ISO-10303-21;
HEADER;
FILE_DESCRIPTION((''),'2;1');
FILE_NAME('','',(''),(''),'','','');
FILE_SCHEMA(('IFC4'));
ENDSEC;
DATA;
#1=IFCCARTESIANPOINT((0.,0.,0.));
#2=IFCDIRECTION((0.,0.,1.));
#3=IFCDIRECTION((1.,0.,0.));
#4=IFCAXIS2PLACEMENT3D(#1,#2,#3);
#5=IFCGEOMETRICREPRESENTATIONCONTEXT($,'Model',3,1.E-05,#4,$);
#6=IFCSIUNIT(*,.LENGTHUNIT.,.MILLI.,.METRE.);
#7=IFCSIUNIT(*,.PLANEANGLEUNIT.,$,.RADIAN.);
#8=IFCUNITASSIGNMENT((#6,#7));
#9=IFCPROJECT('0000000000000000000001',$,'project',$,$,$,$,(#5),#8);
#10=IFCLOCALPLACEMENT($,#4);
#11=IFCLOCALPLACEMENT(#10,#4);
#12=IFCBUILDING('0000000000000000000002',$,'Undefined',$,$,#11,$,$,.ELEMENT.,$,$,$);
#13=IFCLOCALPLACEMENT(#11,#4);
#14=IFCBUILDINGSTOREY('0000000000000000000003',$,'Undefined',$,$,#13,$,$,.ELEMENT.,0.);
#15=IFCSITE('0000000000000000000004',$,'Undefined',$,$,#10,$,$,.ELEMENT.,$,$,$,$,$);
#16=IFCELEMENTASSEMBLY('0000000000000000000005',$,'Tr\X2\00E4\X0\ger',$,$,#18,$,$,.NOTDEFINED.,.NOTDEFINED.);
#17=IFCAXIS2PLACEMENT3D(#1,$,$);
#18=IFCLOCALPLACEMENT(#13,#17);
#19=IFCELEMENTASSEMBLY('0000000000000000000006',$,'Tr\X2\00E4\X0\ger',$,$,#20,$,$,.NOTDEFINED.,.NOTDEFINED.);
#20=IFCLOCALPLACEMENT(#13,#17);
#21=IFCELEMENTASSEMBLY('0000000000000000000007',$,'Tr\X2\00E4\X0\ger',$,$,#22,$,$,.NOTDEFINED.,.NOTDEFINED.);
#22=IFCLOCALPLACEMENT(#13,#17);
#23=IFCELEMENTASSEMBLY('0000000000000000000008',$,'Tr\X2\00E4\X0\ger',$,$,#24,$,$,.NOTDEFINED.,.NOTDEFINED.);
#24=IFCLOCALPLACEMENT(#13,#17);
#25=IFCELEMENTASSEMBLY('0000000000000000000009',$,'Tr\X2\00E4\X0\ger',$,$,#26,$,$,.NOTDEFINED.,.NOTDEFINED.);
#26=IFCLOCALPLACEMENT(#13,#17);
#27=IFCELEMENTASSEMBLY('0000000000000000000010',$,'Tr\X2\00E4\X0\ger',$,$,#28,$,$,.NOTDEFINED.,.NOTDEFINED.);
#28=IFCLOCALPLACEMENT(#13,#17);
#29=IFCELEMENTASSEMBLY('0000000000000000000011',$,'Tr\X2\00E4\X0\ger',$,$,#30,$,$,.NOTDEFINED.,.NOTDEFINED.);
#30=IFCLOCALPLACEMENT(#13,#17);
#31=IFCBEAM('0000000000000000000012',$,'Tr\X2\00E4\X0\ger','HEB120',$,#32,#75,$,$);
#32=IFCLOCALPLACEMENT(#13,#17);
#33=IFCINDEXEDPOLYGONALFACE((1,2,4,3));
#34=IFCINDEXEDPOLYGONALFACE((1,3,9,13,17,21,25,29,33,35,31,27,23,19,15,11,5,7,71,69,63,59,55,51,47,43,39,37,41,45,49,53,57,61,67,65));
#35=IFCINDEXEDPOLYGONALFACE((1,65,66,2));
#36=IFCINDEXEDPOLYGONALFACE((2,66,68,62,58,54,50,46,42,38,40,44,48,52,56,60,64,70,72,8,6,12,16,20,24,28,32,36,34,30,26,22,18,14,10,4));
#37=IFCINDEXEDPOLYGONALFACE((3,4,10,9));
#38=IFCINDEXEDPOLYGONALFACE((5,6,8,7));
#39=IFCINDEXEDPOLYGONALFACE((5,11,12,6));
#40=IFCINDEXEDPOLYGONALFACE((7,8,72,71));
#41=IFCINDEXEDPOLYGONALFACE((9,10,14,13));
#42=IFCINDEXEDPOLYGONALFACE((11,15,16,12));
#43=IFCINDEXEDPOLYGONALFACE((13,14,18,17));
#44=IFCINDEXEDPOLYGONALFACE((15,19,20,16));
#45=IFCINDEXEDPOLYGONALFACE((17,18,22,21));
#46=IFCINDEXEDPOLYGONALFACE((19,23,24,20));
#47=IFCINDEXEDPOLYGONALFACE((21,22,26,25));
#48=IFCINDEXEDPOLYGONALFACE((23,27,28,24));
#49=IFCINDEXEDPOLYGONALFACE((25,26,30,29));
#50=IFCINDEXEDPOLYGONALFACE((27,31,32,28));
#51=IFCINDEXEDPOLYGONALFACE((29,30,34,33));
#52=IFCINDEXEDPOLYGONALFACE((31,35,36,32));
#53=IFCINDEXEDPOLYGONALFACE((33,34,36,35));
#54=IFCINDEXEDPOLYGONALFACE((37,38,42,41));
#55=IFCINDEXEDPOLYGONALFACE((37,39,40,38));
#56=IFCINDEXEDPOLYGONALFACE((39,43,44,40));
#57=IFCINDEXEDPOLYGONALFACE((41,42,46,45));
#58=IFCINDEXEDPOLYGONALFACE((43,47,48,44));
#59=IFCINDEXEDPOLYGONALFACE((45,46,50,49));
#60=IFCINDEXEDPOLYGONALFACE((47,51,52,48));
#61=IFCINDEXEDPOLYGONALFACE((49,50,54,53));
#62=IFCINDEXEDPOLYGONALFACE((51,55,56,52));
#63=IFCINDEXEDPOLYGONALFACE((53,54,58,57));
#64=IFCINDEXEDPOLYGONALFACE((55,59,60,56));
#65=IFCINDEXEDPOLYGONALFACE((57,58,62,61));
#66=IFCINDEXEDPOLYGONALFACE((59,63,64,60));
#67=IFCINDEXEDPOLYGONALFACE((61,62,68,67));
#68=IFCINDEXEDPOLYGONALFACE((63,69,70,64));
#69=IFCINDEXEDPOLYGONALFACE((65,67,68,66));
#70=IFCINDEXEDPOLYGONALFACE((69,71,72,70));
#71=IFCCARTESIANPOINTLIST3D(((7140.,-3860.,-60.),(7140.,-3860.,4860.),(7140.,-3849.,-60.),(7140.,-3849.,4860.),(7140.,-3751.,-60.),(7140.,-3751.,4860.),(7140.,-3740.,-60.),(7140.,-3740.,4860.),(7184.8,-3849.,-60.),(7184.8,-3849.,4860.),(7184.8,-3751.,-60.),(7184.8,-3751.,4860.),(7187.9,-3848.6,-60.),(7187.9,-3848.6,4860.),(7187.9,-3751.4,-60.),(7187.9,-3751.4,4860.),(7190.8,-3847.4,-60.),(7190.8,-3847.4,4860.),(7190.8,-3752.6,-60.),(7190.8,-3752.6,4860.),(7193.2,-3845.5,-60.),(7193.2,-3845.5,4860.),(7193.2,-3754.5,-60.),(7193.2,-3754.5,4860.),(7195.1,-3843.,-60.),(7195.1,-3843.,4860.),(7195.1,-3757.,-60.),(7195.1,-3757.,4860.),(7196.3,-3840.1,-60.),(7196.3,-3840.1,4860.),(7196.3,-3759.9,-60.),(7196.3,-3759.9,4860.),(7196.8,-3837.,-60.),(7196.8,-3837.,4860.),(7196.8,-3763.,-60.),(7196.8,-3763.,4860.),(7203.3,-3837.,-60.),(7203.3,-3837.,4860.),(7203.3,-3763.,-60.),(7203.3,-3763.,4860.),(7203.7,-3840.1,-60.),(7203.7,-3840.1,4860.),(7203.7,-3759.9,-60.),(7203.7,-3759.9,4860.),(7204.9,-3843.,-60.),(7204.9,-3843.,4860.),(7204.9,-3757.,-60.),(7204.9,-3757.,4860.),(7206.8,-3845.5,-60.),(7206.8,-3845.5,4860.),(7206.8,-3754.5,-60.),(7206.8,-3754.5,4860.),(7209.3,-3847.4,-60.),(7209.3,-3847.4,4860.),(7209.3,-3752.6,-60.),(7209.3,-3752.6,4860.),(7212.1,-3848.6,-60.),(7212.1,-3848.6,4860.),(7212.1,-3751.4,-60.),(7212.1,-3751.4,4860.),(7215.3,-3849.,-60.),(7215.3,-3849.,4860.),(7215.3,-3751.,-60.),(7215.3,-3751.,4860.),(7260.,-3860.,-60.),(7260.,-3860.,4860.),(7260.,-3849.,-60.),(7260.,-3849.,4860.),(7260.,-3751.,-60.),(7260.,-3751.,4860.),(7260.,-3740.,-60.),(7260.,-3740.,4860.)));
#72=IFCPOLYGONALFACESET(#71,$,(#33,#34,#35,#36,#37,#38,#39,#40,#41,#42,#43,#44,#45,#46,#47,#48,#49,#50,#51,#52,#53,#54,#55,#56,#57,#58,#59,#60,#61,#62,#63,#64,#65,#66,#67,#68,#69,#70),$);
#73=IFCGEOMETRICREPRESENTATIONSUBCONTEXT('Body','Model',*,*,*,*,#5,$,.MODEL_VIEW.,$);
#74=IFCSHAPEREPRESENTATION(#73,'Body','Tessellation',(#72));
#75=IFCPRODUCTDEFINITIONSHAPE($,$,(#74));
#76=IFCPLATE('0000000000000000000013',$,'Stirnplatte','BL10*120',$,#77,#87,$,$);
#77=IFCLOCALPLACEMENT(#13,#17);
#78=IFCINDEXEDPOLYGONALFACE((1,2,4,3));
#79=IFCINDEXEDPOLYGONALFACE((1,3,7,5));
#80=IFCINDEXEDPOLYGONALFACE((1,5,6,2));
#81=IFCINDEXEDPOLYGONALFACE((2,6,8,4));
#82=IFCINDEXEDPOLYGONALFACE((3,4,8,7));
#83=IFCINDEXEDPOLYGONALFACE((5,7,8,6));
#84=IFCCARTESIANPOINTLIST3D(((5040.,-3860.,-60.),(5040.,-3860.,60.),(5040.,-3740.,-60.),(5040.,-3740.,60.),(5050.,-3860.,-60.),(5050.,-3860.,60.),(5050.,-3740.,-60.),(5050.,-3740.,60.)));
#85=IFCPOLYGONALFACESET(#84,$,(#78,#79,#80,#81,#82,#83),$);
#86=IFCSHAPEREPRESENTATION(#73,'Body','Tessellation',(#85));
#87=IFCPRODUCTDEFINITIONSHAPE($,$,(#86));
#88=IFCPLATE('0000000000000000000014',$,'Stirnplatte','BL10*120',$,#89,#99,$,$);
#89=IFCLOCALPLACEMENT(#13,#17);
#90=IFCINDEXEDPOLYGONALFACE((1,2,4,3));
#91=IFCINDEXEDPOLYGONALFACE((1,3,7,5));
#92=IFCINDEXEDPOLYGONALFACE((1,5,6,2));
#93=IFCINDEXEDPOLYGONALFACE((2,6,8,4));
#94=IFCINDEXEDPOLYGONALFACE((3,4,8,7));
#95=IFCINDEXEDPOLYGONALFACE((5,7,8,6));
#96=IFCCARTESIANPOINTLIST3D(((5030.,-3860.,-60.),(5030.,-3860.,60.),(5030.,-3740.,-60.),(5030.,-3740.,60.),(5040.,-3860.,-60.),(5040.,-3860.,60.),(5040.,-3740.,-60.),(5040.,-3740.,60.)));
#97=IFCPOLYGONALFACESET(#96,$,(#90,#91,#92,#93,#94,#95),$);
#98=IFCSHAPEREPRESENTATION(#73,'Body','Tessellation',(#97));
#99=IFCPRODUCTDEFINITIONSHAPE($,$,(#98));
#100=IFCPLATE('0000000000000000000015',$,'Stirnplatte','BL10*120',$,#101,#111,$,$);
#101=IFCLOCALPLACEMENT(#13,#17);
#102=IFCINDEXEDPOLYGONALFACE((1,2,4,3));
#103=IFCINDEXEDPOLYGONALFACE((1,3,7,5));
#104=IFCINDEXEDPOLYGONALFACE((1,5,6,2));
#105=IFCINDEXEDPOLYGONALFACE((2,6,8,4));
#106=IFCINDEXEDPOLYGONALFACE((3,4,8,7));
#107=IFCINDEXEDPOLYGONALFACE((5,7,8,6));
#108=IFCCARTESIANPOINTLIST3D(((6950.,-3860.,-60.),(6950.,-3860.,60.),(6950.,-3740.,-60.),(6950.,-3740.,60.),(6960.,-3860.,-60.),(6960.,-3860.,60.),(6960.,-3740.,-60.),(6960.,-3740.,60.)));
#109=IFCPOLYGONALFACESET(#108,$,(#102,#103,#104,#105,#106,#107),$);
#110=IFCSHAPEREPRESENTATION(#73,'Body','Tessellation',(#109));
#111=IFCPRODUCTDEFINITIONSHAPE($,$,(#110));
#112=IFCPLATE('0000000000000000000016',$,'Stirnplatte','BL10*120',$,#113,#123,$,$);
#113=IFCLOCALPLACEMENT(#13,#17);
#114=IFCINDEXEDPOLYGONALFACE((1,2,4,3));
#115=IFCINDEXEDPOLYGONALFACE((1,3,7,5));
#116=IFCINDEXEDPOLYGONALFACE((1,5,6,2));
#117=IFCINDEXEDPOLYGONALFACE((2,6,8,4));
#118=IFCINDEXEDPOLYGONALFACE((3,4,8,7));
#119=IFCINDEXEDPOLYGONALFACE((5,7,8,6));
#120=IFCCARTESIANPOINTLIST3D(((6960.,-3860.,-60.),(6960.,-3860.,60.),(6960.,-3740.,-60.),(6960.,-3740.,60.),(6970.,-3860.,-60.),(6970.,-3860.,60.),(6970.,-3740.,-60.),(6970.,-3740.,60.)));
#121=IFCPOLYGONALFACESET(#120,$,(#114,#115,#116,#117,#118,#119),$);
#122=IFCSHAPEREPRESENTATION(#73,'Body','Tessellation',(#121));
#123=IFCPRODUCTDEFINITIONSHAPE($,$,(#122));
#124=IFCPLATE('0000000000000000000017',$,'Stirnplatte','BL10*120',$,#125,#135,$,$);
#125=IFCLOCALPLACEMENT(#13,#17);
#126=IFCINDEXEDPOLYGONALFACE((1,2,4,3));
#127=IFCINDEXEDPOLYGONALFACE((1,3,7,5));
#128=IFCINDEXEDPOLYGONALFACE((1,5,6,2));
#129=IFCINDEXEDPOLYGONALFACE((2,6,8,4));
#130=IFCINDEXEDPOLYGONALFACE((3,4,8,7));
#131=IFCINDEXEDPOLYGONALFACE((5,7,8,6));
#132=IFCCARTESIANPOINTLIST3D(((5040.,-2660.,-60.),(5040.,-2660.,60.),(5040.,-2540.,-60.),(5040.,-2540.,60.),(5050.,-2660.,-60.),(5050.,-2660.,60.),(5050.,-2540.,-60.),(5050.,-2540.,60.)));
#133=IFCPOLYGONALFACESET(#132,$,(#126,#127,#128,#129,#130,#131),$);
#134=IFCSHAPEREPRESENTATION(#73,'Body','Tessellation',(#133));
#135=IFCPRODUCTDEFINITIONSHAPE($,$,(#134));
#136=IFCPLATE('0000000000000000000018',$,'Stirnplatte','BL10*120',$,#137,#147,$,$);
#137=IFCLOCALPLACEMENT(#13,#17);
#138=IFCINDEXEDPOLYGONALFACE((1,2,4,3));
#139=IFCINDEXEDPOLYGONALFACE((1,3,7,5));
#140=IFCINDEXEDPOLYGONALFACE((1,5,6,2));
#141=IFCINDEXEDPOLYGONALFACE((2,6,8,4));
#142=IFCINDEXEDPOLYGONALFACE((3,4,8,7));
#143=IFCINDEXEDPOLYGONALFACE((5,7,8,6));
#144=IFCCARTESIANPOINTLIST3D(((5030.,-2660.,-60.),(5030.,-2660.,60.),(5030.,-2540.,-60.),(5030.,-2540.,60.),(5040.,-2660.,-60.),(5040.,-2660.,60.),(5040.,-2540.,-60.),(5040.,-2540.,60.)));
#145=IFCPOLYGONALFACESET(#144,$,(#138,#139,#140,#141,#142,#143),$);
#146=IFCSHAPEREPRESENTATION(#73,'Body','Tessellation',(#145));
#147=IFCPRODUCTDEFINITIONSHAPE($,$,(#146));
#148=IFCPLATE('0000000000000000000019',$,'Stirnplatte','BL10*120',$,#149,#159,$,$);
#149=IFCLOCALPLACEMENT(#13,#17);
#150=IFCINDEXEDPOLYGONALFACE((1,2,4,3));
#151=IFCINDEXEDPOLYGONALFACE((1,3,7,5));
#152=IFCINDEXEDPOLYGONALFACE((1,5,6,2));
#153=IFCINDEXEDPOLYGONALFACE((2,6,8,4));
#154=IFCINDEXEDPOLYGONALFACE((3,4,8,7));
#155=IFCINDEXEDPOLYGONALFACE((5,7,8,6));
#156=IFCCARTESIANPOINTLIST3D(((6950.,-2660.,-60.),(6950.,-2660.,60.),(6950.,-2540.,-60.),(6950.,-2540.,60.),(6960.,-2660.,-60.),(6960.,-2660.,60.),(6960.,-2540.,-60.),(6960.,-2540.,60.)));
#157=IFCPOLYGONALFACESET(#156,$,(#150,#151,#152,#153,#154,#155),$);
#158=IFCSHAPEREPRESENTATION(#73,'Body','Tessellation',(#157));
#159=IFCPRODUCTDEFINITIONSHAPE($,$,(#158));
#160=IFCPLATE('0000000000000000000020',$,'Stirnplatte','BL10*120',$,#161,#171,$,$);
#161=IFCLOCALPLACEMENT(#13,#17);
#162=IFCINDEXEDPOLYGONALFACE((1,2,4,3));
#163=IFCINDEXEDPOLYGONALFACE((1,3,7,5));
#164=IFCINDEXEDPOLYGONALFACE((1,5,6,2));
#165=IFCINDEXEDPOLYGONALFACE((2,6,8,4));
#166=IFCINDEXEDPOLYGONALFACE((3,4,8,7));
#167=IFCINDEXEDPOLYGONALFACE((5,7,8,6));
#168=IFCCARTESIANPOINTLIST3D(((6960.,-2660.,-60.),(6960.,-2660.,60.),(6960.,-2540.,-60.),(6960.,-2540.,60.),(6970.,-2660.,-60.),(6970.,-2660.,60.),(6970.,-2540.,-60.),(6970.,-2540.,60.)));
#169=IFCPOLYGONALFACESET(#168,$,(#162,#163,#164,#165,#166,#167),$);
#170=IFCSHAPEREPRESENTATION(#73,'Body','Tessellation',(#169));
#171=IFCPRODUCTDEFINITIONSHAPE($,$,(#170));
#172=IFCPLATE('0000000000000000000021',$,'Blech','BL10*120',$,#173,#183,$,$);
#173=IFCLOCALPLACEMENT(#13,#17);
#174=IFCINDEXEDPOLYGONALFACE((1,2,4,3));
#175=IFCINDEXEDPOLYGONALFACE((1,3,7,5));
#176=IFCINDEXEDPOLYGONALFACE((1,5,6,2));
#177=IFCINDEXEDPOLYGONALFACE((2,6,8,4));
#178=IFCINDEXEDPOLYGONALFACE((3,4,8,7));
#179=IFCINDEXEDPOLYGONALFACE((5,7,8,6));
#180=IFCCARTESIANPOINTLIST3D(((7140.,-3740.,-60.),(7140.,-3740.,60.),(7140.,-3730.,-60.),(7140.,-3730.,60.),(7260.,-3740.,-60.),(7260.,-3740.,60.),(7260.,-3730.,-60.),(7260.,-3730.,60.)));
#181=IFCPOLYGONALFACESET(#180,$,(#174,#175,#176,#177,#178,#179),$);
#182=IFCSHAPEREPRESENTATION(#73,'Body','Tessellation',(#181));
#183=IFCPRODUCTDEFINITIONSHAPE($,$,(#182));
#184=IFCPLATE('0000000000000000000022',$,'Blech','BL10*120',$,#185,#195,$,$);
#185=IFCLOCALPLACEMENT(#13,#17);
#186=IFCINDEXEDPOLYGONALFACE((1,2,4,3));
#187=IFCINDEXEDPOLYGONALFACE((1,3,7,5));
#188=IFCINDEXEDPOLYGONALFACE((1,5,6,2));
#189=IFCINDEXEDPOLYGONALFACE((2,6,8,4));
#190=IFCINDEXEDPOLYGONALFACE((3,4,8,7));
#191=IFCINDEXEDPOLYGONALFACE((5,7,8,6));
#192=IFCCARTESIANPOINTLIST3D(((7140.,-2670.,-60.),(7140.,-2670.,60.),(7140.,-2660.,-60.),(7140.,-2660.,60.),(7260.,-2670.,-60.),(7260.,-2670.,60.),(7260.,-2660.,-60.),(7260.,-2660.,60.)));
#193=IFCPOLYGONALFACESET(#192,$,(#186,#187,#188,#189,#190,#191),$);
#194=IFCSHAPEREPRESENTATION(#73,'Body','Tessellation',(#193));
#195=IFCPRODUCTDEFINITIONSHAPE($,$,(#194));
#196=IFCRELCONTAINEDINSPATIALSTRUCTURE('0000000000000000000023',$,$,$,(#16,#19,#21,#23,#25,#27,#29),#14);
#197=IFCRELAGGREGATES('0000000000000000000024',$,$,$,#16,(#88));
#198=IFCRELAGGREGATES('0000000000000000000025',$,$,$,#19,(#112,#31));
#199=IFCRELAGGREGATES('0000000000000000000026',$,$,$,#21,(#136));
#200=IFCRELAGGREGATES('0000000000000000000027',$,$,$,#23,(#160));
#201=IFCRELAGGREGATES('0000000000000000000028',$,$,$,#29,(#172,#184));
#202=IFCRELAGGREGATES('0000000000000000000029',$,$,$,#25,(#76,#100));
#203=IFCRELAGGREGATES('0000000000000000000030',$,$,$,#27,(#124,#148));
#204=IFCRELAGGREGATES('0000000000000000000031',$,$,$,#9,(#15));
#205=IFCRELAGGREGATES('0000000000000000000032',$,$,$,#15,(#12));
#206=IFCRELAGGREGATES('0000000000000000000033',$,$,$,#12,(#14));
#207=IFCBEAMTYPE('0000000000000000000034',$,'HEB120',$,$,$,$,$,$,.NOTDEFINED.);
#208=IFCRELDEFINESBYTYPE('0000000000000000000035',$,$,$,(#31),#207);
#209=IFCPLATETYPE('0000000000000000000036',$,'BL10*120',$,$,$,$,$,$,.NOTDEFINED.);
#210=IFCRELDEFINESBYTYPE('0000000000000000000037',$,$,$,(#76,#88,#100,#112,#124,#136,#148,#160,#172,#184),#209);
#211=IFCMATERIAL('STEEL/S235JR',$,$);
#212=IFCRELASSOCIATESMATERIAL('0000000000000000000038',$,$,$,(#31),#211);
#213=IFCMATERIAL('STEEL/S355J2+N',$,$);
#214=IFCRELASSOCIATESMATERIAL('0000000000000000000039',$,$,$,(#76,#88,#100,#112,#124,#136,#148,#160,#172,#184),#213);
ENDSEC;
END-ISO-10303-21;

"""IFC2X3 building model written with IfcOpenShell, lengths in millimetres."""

from ifc_helpers import new_model, si_unit, frame, origin_with_axes, origin_2d_with_axis, place, context, subcontext, project, spatial, polyline, i_section, outline, extrude, material, type_object, element, aggregate, save


model = new_model("IFC2X3")

# Units and contexts
model_context = context("Model", 3, precision=1e-05, world=origin_with_axes())
body_context = subcontext(model_context, "Body", "Model", "MODEL_VIEW")
ifc_project = project(units=[si_unit("LENGTHUNIT", "METRE", prefix="MILLI"), si_unit("PLANEANGLEUNIT", "RADIAN")], contexts=[model_context])

# Site, building, storey
site_placement = place(None, origin_with_axes())
site = spatial("IfcSite", under=ifc_project, at=site_placement, Name="Undefined", CompositionType="ELEMENT")
building_placement = place(site_placement, origin_with_axes())
building = spatial("IfcBuilding", under=site, at=building_placement, Name="Undefined", CompositionType="ELEMENT")
storey_placement = place(building_placement, origin_with_axes())
storey = spatial("IfcBuildingStorey", under=building, at=storey_placement, Name="Undefined", CompositionType="ELEMENT", Elevation=0.0)

# Element assemblies
assembly_1_placement = place(storey_placement, origin_with_axes())
assembly_1 = element("IfcElementAssembly", 1, at=assembly_1_placement, inside=storey, Name="Träger", AssemblyPlace="NOTDEFINED", PredefinedType="NOTDEFINED")
ifc_material_1 = material(Name="STEEL/S235JR")
beam_type = type_object("IfcBeamType", Name="HEB120", PredefinedType="NOTDEFINED")
assembly_2_placement = place(storey_placement, origin_with_axes())
assembly_2 = element("IfcElementAssembly", 2, at=assembly_2_placement, inside=storey, Name="Träger", AssemblyPlace="NOTDEFINED", PredefinedType="NOTDEFINED")
assembly_3_placement = place(storey_placement, origin_with_axes())
assembly_3 = element("IfcElementAssembly", 3, at=assembly_3_placement, inside=storey, Name="Träger", AssemblyPlace="NOTDEFINED", PredefinedType="NOTDEFINED")
assembly_4_placement = place(storey_placement, origin_with_axes())
assembly_4 = element("IfcElementAssembly", 4, at=assembly_4_placement, inside=storey, Name="Träger", AssemblyPlace="NOTDEFINED", PredefinedType="NOTDEFINED")
assembly_5_placement = place(storey_placement, origin_with_axes())
assembly_5 = element("IfcElementAssembly", 5, at=assembly_5_placement, inside=storey, Name="Träger", AssemblyPlace="NOTDEFINED", PredefinedType="NOTDEFINED")
assembly_6_placement = place(storey_placement, origin_with_axes())
assembly_6 = element("IfcElementAssembly", 6, at=assembly_6_placement, inside=storey, Name="Träger", AssemblyPlace="NOTDEFINED", PredefinedType="NOTDEFINED")
assembly_7_placement = place(storey_placement, origin_with_axes())
assembly_7 = element("IfcElementAssembly", 7, at=assembly_7_placement, inside=storey, Name="Träger", AssemblyPlace="NOTDEFINED", PredefinedType="NOTDEFINED")

# Beam
beam_1_placement = place(assembly_2_placement, frame((7200.0, -3800.0, -60.0), z_axis=(0.0, 1.0, 0.0), x_axis=(0.0, 0.0, 1.0)))
beam_1 = element("IfcBeam", 8, at=beam_1_placement, type_object=beam_type, material=ifc_material_1, Name="Träger", Description="HEB120", context=body_context, shape_type="SweptSolid", body=[
    extrude(i_section(OverallWidth=120.0, OverallDepth=120.0, WebThickness=6.5, FlangeThickness=11.0, FilletRadius=12.0, at=origin_2d_with_axis()), frame((4920.0, 0.0, 0.0), z_axis=(-1.0, 0.0, 0.0), x_axis=(0.0, -1.0, 0.0)), (0.0, 0.0, 1.0), 4920.0),
])

# Plates
ifc_material_2 = material(Name="STEEL/S355J2+N")
plate_type = type_object("IfcPlateType", Name="BL10*120", PredefinedType="NOTDEFINED")
plate_1_placement = place(assembly_5_placement, frame((5045.0, -3800.0, -60.0), z_axis=(1.0, 0.0, 0.0), x_axis=(0.0, 0.0, 1.0)))
plate_1 = element("IfcPlate", 9, at=plate_1_placement, type_object=plate_type, material=ifc_material_2, Name="Stirnplatte", Description="BL10*120", context=body_context, shape_type="SweptSolid", body=[
    extrude(outline(polyline([(0.0, -60.0), (0.0, 60.0), (120.0, 60.0), (120.0, -60.0), (0.0, -60.0)])), frame((0.0, 0.0, -5.0), z_axis=(0.0, 0.0, 1.0), x_axis=(1.0, 0.0, 0.0)), (0.0, 0.0, 1.0), 10.0),
])
plate_2_placement = place(assembly_1_placement, frame((5035.0, -3800.0, -60.0), z_axis=(1.0, 0.0, 0.0), x_axis=(0.0, 0.0, 1.0)))
plate_2 = element("IfcPlate", 10, at=plate_2_placement, type_object=plate_type, material=ifc_material_2, Name="Stirnplatte", Description="BL10*120", context=body_context, shape_type="SweptSolid", body=[
    extrude(outline(polyline([(0.0, -60.0), (0.0, 60.0), (120.0, 60.0), (120.0, -60.0), (0.0, -60.0)])), frame((0.0, 0.0, -5.0), z_axis=(0.0, 0.0, 1.0), x_axis=(1.0, 0.0, 0.0)), (0.0, 0.0, 1.0), 10.0),
])
aggregate(assembly_1, [plate_2])
plate_3_placement = place(assembly_5_placement, frame((6955.0, -3800.0, -60.0), z_axis=(-1.0, 0.0, 0.0), x_axis=(0.0, 0.0, 1.0)))
plate_3 = element("IfcPlate", 11, at=plate_3_placement, type_object=plate_type, material=ifc_material_2, Name="Stirnplatte", Description="BL10*120", context=body_context, shape_type="SweptSolid", body=[
    extrude(outline(polyline([(0.0, -60.0), (0.0, 60.0), (120.0, 60.0), (120.0, -60.0), (0.0, -60.0)])), frame((0.0, 0.0, -5.0), z_axis=(0.0, 0.0, 1.0), x_axis=(1.0, 0.0, 0.0)), (0.0, 0.0, 1.0), 10.0),
])
plate_4_placement = place(assembly_2_placement, frame((6965.0, -3800.0, -60.0), z_axis=(-1.0, 0.0, 0.0), x_axis=(0.0, 0.0, 1.0)))
plate_4 = element("IfcPlate", 12, at=plate_4_placement, type_object=plate_type, material=ifc_material_2, Name="Stirnplatte", Description="BL10*120", context=body_context, shape_type="SweptSolid", body=[
    extrude(outline(polyline([(0.0, -60.0), (0.0, 60.0), (120.0, 60.0), (120.0, -60.0), (0.0, -60.0)])), frame((0.0, 0.0, -5.0), z_axis=(0.0, 0.0, 1.0), x_axis=(1.0, 0.0, 0.0)), (0.0, 0.0, 1.0), 10.0),
])
aggregate(assembly_2, [plate_4, beam_1])
plate_5_placement = place(assembly_6_placement, frame((5045.0, -2600.0, -60.0), z_axis=(1.0, 0.0, 0.0), x_axis=(0.0, 0.0, 1.0)))
plate_5 = element("IfcPlate", 13, at=plate_5_placement, type_object=plate_type, material=ifc_material_2, Name="Stirnplatte", Description="BL10*120", context=body_context, shape_type="SweptSolid", body=[
    extrude(outline(polyline([(0.0, -60.0), (0.0, 60.0), (120.0, 60.0), (120.0, -60.0), (0.0, -60.0)])), frame((0.0, 0.0, -5.0), z_axis=(0.0, 0.0, 1.0), x_axis=(1.0, 0.0, 0.0)), (0.0, 0.0, 1.0), 10.0),
])
plate_6_placement = place(assembly_3_placement, frame((5035.0, -2600.0, -60.0), z_axis=(1.0, 0.0, 0.0), x_axis=(0.0, 0.0, 1.0)))
plate_6 = element("IfcPlate", 14, at=plate_6_placement, type_object=plate_type, material=ifc_material_2, Name="Stirnplatte", Description="BL10*120", context=body_context, shape_type="SweptSolid", body=[
    extrude(outline(polyline([(0.0, -60.0), (0.0, 60.0), (120.0, 60.0), (120.0, -60.0), (0.0, -60.0)])), frame((0.0, 0.0, -5.0), z_axis=(0.0, 0.0, 1.0), x_axis=(1.0, 0.0, 0.0)), (0.0, 0.0, 1.0), 10.0),
])
aggregate(assembly_3, [plate_6])
plate_7_placement = place(assembly_6_placement, frame((6955.0, -2600.0, -60.0), z_axis=(-1.0, 0.0, 0.0), x_axis=(0.0, 0.0, 1.0)))
plate_7 = element("IfcPlate", 15, at=plate_7_placement, type_object=plate_type, material=ifc_material_2, Name="Stirnplatte", Description="BL10*120", context=body_context, shape_type="SweptSolid", body=[
    extrude(outline(polyline([(0.0, -60.0), (0.0, 60.0), (120.0, 60.0), (120.0, -60.0), (0.0, -60.0)])), frame((0.0, 0.0, -5.0), z_axis=(0.0, 0.0, 1.0), x_axis=(1.0, 0.0, 0.0)), (0.0, 0.0, 1.0), 10.0),
])
plate_8_placement = place(assembly_4_placement, frame((6965.0, -2600.0, -60.0), z_axis=(-1.0, 0.0, 0.0), x_axis=(0.0, 0.0, 1.0)))
plate_8 = element("IfcPlate", 16, at=plate_8_placement, type_object=plate_type, material=ifc_material_2, Name="Stirnplatte", Description="BL10*120", context=body_context, shape_type="SweptSolid", body=[
    extrude(outline(polyline([(0.0, -60.0), (0.0, 60.0), (120.0, 60.0), (120.0, -60.0), (0.0, -60.0)])), frame((0.0, 0.0, -5.0), z_axis=(0.0, 0.0, 1.0), x_axis=(1.0, 0.0, 0.0)), (0.0, 0.0, 1.0), 10.0),
])
aggregate(assembly_4, [plate_8])
plate_9_placement = place(assembly_7_placement, frame((7200.0, -3735.0, -60.0), z_axis=(0.0, 1.0, 0.0), x_axis=(0.0, 0.0, 1.0)))
plate_9 = element("IfcPlate", 17, at=plate_9_placement, type_object=plate_type, material=ifc_material_2, Name="Blech", Description="BL10*120", context=body_context, shape_type="SweptSolid", body=[
    extrude(outline(polyline([(0.0, -60.0), (0.0, 60.0), (120.0, 60.0), (120.0, -60.0), (0.0, -60.0)])), frame((0.0, 0.0, -5.0), z_axis=(0.0, 0.0, 1.0), x_axis=(1.0, 0.0, 0.0)), (0.0, 0.0, 1.0), 10.0),
])
plate_10_placement = place(assembly_7_placement, frame((7200.0, -2665.0, -60.0), z_axis=(0.0, -1.0, 0.0), x_axis=(0.0, 0.0, 1.0)))
plate_10 = element("IfcPlate", 18, at=plate_10_placement, type_object=plate_type, material=ifc_material_2, Name="Blech", Description="BL10*120", context=body_context, shape_type="SweptSolid", body=[
    extrude(outline(polyline([(0.0, -60.0), (0.0, 60.0), (120.0, 60.0), (120.0, -60.0), (0.0, -60.0)])), frame((0.0, 0.0, -5.0), z_axis=(0.0, 0.0, 1.0), x_axis=(1.0, 0.0, 0.0)), (0.0, 0.0, 1.0), 10.0),
])
aggregate(assembly_7, [plate_9, plate_10])

aggregate(assembly_5, [plate_1, plate_3])
aggregate(assembly_6, [plate_5, plate_7])

save(model, "model.ifc")
